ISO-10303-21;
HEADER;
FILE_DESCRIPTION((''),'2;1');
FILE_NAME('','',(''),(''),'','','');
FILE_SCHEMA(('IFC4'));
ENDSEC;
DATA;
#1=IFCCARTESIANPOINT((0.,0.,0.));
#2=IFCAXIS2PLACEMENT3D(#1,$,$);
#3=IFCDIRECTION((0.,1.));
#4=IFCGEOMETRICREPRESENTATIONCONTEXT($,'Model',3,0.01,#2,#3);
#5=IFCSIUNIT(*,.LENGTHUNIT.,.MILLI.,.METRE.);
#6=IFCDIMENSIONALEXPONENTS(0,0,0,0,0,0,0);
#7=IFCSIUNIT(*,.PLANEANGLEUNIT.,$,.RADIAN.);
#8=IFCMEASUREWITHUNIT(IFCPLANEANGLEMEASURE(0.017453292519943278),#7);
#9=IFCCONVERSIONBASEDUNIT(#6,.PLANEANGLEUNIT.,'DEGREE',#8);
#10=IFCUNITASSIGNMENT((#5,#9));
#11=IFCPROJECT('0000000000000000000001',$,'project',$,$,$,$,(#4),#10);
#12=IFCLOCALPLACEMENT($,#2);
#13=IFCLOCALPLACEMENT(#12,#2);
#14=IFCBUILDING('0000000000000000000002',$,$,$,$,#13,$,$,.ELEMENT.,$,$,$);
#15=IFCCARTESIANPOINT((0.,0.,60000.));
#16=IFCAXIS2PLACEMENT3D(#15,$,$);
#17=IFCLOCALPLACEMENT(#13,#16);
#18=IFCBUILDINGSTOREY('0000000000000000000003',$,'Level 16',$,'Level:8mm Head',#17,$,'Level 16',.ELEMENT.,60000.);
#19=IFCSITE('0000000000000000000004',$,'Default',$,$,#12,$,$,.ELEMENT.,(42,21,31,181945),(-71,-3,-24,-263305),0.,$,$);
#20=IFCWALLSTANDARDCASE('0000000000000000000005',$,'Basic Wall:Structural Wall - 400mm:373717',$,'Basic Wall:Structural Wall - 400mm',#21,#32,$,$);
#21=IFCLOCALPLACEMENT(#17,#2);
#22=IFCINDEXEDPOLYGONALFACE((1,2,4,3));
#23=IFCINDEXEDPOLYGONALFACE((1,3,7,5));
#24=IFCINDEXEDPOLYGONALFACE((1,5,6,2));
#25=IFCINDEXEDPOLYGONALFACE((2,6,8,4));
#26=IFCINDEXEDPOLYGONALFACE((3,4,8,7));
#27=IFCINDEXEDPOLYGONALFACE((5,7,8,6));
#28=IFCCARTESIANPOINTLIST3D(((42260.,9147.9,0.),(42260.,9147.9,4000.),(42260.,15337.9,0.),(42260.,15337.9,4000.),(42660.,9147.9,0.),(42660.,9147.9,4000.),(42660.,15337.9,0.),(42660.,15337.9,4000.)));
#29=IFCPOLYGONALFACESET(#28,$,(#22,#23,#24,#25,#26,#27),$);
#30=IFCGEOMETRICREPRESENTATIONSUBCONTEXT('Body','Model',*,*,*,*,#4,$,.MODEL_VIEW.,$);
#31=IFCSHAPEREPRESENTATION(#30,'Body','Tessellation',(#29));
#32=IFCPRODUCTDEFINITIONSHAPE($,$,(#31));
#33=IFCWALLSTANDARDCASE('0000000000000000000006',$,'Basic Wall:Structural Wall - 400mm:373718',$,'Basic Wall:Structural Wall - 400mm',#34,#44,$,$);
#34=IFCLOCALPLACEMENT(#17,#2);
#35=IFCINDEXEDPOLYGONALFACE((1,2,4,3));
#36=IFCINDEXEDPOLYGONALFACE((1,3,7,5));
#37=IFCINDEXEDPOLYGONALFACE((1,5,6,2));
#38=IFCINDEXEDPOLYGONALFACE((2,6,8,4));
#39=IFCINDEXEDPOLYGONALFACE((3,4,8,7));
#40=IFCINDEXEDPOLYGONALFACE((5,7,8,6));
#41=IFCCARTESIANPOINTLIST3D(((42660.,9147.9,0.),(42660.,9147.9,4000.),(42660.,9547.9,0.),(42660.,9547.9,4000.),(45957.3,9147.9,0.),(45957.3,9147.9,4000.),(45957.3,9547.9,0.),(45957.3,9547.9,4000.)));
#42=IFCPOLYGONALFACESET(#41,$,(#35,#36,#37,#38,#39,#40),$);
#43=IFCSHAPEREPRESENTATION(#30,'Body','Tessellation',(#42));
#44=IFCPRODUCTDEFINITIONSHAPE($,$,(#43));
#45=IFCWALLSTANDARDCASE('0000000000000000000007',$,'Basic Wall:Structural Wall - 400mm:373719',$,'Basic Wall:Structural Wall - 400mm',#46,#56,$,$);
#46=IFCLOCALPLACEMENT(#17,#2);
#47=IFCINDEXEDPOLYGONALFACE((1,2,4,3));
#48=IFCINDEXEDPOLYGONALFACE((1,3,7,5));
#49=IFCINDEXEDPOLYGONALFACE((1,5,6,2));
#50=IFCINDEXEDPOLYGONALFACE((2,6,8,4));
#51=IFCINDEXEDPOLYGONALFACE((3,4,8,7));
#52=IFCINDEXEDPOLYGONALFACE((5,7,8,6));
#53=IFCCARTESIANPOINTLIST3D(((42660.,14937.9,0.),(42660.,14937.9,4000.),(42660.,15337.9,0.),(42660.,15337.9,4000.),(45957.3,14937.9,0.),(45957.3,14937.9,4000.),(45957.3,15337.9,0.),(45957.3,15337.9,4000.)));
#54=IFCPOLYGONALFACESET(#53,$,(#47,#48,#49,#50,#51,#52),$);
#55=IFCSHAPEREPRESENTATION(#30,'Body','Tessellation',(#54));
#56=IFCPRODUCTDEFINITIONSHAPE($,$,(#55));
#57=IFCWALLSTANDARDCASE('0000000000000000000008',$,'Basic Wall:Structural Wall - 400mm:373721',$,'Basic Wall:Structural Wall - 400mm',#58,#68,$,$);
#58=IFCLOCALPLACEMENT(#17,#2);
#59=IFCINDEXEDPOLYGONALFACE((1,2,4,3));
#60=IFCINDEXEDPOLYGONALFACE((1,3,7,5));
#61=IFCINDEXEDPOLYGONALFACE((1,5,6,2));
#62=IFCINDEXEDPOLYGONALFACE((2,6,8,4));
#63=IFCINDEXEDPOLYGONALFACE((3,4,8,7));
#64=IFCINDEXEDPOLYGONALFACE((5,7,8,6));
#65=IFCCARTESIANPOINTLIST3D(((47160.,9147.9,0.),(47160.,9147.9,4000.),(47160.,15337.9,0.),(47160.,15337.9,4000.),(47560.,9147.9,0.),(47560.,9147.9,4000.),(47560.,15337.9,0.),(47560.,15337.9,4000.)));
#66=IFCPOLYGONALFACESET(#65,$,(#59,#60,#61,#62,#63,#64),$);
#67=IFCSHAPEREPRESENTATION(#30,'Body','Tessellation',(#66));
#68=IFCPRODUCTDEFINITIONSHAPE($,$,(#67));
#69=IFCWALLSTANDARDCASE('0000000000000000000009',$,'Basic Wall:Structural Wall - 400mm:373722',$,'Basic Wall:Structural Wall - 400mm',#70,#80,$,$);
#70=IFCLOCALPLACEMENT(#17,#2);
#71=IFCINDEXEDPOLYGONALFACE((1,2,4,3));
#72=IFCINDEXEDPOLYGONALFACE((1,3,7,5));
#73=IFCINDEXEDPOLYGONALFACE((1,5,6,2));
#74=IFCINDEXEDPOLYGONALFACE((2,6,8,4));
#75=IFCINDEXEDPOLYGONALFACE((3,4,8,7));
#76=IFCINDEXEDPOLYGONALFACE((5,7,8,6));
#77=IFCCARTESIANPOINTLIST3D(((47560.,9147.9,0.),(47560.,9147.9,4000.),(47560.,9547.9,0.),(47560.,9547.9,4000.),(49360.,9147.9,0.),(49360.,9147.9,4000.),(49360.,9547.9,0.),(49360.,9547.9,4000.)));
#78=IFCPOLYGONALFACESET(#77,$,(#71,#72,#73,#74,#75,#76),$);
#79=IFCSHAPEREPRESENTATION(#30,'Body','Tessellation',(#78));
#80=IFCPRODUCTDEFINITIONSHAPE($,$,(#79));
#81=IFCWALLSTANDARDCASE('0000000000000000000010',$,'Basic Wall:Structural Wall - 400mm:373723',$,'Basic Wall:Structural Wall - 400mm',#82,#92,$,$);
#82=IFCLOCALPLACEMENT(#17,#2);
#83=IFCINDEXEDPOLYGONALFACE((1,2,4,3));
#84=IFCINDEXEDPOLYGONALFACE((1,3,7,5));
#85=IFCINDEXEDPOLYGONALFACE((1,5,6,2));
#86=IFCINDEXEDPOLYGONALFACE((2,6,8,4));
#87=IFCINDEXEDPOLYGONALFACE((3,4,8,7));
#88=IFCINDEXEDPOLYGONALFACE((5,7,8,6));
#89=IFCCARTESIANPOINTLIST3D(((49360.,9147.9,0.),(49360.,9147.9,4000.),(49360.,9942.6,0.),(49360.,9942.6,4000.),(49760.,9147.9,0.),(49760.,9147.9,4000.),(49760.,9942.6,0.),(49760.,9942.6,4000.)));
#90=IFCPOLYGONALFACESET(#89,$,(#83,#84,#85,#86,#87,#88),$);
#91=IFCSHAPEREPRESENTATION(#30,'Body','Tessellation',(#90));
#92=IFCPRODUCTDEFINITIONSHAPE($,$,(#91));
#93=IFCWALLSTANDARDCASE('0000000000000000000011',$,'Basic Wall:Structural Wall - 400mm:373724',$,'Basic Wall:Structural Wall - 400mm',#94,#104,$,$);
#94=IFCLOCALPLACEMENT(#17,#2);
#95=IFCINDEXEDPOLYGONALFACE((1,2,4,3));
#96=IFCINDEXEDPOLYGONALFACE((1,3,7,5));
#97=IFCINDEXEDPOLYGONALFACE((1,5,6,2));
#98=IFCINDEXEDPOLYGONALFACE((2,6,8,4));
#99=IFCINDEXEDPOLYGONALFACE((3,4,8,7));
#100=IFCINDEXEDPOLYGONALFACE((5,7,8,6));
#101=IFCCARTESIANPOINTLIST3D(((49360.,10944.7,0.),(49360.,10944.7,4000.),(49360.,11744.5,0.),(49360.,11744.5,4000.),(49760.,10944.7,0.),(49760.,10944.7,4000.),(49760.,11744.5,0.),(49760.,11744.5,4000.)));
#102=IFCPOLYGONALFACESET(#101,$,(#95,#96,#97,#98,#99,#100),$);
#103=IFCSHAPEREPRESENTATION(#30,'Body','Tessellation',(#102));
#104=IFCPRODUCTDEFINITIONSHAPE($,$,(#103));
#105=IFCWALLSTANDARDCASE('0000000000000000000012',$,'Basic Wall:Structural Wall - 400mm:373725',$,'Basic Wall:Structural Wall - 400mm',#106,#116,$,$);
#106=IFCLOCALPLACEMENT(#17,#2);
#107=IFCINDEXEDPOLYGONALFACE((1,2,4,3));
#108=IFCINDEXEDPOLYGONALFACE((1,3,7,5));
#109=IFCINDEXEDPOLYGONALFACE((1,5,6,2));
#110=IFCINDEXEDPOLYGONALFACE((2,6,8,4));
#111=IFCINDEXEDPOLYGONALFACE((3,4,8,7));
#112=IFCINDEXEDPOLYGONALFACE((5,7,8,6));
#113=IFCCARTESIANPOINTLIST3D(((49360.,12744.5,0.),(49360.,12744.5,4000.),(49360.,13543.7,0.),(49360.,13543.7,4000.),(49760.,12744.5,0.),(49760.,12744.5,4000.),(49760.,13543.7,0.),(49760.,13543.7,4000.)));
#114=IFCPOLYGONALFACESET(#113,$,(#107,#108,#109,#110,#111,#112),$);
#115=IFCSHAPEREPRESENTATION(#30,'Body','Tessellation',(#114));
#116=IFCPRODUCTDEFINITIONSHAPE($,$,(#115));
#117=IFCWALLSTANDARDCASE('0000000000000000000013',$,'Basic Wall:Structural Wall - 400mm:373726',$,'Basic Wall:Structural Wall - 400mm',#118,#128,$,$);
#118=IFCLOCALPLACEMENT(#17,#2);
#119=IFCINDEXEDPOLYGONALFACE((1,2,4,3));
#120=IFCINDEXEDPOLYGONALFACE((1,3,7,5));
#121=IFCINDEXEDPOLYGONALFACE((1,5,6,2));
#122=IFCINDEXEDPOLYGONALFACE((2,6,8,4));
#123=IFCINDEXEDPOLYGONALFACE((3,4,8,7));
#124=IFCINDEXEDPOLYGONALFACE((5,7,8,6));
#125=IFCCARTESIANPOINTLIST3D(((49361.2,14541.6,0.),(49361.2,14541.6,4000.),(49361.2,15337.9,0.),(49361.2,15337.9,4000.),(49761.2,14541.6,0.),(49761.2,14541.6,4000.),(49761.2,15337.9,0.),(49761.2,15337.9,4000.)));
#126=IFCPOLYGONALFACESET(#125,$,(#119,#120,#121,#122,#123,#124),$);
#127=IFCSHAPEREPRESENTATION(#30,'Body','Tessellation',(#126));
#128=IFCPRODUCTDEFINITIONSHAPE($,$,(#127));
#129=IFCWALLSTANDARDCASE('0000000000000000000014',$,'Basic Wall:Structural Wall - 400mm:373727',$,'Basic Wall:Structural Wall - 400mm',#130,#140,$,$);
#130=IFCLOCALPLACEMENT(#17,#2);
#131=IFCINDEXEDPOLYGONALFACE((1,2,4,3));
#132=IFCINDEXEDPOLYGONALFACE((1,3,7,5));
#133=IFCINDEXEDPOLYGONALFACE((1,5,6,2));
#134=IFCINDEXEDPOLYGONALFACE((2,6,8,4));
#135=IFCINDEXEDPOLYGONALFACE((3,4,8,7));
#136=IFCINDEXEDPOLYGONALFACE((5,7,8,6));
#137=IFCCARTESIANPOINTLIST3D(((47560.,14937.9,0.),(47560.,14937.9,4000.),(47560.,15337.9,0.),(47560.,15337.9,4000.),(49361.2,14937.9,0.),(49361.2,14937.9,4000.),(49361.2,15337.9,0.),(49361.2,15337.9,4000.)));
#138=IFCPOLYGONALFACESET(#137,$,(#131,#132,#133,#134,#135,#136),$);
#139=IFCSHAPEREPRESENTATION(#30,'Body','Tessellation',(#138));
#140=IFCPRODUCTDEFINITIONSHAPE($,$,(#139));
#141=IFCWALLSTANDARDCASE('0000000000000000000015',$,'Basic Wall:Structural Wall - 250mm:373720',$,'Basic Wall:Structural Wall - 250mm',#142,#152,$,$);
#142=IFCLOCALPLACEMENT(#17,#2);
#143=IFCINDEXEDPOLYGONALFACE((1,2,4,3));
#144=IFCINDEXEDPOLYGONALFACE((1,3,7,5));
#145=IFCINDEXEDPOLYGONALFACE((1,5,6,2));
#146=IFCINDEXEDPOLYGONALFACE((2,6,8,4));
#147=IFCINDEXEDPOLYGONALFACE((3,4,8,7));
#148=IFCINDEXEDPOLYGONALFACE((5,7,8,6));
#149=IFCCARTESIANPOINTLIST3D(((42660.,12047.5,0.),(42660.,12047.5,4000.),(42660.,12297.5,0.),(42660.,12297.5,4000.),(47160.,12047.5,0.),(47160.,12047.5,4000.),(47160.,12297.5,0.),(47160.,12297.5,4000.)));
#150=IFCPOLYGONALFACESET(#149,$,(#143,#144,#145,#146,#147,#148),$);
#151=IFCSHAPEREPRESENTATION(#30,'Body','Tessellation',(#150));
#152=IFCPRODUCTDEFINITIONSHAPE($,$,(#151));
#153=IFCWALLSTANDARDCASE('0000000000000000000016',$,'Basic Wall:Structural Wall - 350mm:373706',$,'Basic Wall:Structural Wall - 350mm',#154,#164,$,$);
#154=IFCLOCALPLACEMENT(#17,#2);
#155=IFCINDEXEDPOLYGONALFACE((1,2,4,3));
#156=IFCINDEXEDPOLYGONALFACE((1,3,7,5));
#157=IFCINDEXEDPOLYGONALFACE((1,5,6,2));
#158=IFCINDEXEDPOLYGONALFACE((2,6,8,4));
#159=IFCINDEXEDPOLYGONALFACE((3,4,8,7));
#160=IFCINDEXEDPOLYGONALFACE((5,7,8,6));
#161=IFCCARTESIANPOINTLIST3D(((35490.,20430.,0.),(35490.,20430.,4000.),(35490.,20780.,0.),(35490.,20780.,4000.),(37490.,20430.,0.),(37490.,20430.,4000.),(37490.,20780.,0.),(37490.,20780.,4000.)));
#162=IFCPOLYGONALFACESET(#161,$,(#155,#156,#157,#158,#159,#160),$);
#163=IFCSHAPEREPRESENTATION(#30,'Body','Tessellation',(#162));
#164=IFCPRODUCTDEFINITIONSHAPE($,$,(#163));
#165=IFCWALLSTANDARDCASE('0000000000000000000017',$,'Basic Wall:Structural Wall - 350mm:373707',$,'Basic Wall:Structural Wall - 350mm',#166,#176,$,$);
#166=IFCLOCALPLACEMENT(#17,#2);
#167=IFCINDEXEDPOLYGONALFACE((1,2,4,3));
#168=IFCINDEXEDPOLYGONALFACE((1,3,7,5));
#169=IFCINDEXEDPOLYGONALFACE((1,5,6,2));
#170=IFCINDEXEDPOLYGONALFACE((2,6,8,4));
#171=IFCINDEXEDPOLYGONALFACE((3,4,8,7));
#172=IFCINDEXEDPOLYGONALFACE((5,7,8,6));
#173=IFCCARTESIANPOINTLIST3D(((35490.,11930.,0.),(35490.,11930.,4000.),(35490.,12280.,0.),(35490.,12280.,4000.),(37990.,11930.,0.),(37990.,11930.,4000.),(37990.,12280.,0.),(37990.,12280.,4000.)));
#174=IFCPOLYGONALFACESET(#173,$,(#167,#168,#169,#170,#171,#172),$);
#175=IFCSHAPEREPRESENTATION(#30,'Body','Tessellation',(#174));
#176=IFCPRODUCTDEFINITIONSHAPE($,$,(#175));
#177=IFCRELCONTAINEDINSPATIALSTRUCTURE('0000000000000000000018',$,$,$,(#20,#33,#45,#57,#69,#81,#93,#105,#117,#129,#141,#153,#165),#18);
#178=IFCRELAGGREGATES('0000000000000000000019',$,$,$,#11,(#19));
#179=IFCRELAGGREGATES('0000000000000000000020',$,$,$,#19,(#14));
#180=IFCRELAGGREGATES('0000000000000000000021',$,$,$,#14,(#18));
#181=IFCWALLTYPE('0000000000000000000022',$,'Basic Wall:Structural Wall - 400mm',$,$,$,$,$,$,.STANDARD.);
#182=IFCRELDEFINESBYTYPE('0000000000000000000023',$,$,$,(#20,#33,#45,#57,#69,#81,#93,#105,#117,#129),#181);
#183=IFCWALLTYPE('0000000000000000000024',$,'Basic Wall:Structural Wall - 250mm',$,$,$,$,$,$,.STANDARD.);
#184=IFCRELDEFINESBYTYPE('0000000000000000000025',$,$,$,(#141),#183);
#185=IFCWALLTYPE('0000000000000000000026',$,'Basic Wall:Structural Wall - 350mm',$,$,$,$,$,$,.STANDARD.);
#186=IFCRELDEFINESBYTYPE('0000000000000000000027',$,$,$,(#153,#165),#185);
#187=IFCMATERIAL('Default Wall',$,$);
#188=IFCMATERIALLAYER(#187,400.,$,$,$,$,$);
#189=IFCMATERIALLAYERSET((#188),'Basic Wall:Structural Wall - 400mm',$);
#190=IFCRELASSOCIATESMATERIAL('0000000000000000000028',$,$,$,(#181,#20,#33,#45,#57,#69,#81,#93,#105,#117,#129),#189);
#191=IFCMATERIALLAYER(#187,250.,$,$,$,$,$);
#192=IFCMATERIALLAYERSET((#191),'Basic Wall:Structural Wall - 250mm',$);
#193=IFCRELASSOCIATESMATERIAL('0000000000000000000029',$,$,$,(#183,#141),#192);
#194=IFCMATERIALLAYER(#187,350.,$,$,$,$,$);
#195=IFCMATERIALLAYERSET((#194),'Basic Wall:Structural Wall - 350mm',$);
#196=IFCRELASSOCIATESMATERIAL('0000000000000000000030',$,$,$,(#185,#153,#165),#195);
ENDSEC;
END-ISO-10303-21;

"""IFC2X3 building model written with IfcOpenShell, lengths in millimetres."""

from ifc_helpers import new_model, entity, si_unit, converted_unit, direction, frame, frame_2d, origin, place, context, subcontext, project, spatial, rectangle, extrude, material, layer, layer_set, layer_usage, type_object, element, save


model = new_model("IFC2X3")

# Units and contexts
model_context = context("Model", 3, precision=0.01, world=origin(), true_north=direction((0.0, 1.0)))
body_context = subcontext(model_context, "Body", "Model", "MODEL_VIEW")
ifc_project = project(units=[si_unit("LENGTHUNIT", "METRE", prefix="MILLI"), converted_unit("PLANEANGLEUNIT", "DEGREE", entity("IfcPlaneAngleMeasure", 0.017453292519943278), si_unit("PLANEANGLEUNIT", "RADIAN"), dimensions=[0, 0, 0, 0, 0, 0, 0])], contexts=[model_context])

# Site, building, storey
site_placement = place(None, origin())
site = spatial("IfcSite", under=ifc_project, at=site_placement, Name="Default", CompositionType="ELEMENT", RefLatitude=(42, 21, 31, 181945), RefLongitude=(-71, -3, -24, -263305), RefElevation=0.0)
building_placement = place(site_placement, origin())
building = spatial("IfcBuilding", under=site, at=building_placement, CompositionType="ELEMENT")
storey_placement = place(building_placement, frame((0.0, 0.0, 60000.0)))
storey = spatial("IfcBuildingStorey", under=building, at=storey_placement, Name="Level 16", ObjectType="Level:8mm Head", LongName="Level 16", CompositionType="ELEMENT", Elevation=60000.0)

# Walls
ifc_material_1 = material(Name="Default Wall")
ifc_layer_1 = layer(ifc_material_1, 400.0)
ifc_layer_set_1 = layer_set([ifc_layer_1], Name="Basic Wall:Structural Wall - 400mm")
ifc_layer_usage_1 = layer_usage(ifc_layer_set_1, "AXIS2", "POSITIVE", -200.0)
wall_type_1 = type_object("IfcWallType", Name="Basic Wall:Structural Wall - 400mm", PredefinedType="STANDARD", material=ifc_layer_set_1)
wall_1_placement = place(storey_placement, frame((42460.0, 15337.9, 0.0), z_axis=(0.0, 0.0, 1.0), x_axis=(0.0, -1.0, 0.0)))
element("IfcWallStandardCase", 1, at=wall_1_placement, inside=storey, type_object=wall_type_1, material=ifc_layer_usage_1, Name="Basic Wall:Structural Wall - 400mm:373717", ObjectType="Basic Wall:Structural Wall - 400mm", context=body_context, shape_type="SweptSolid", body=[
    extrude(rectangle(XDim=6190.0, YDim=400.0, at=frame_2d((3095.0, 0.0), x_axis=(-1.0, 0.0))), origin(), (0.0, 0.0, 1.0), 4000.0),
])
ifc_layer_usage_2 = layer_usage(ifc_layer_set_1, "AXIS2", "POSITIVE", -200.0)
wall_2_placement = place(storey_placement, frame((42660.0, 9347.9, 0.0)))
element("IfcWallStandardCase", 2, at=wall_2_placement, inside=storey, type_object=wall_type_1, material=ifc_layer_usage_2, Name="Basic Wall:Structural Wall - 400mm:373718", ObjectType="Basic Wall:Structural Wall - 400mm", context=body_context, shape_type="SweptSolid", body=[
    extrude(rectangle(XDim=3297.3, YDim=400.0, at=frame_2d((1648.6, 0.0), x_axis=(-1.0, 0.0))), origin(), (0.0, 0.0, 1.0), 4000.0),
])
ifc_layer_usage_3 = layer_usage(ifc_layer_set_1, "AXIS2", "POSITIVE", -200.0)
wall_3_placement = place(storey_placement, frame((45957.3, 15137.9, 0.0), z_axis=(0.0, 0.0, 1.0), x_axis=(-1.0, 0.0, 0.0)))
element("IfcWallStandardCase", 3, at=wall_3_placement, inside=storey, type_object=wall_type_1, material=ifc_layer_usage_3, Name="Basic Wall:Structural Wall - 400mm:373719", ObjectType="Basic Wall:Structural Wall - 400mm", context=body_context, shape_type="SweptSolid", body=[
    extrude(rectangle(XDim=3297.3, YDim=400.0, at=frame_2d((1648.6, 0.0), x_axis=(-1.0, 0.0))), origin(), (0.0, 0.0, 1.0), 4000.0),
])
ifc_layer_usage_4 = layer_usage(ifc_layer_set_1, "AXIS2", "POSITIVE", -200.0)
wall_4_placement = place(storey_placement, frame((47360.0, 15337.9, 0.0), z_axis=(0.0, 0.0, 1.0), x_axis=(0.0, -1.0, 0.0)))
element("IfcWallStandardCase", 4, at=wall_4_placement, inside=storey, type_object=wall_type_1, material=ifc_layer_usage_4, Name="Basic Wall:Structural Wall - 400mm:373721", ObjectType="Basic Wall:Structural Wall - 400mm", context=body_context, shape_type="SweptSolid", body=[
    extrude(rectangle(XDim=6190.0, YDim=400.0, at=frame_2d((3095.0, 0.0), x_axis=(-1.0, 0.0))), origin(), (0.0, 0.0, 1.0), 4000.0),
])
ifc_layer_usage_5 = layer_usage(ifc_layer_set_1, "AXIS2", "POSITIVE", -200.0)
wall_5_placement = place(storey_placement, frame((47560.0, 9347.9, 0.0)))
element("IfcWallStandardCase", 5, at=wall_5_placement, inside=storey, type_object=wall_type_1, material=ifc_layer_usage_5, Name="Basic Wall:Structural Wall - 400mm:373722", ObjectType="Basic Wall:Structural Wall - 400mm", context=body_context, shape_type="SweptSolid", body=[
    extrude(rectangle(XDim=1800.0, YDim=400.0, at=frame_2d((900.0, 0.0), x_axis=(-1.0, 0.0))), origin(), (0.0, 0.0, 1.0), 4000.0),
])
ifc_layer_usage_6 = layer_usage(ifc_layer_set_1, "AXIS2", "NEGATIVE", 200.0)
wall_6_placement = place(storey_placement, frame((49560.0, 9147.9, 0.0), z_axis=(0.0, 0.0, 1.0), x_axis=(0.0, 1.0, 0.0)))
element("IfcWallStandardCase", 6, at=wall_6_placement, inside=storey, type_object=wall_type_1, material=ifc_layer_usage_6, Name="Basic Wall:Structural Wall - 400mm:373723", ObjectType="Basic Wall:Structural Wall - 400mm", context=body_context, shape_type="SweptSolid", body=[
    extrude(rectangle(XDim=794.7, YDim=400.0, at=frame_2d((397.3, 0.0), x_axis=(-1.0, 0.0))), origin(), (0.0, 0.0, 1.0), 4000.0),
])
ifc_layer_usage_7 = layer_usage(ifc_layer_set_1, "AXIS2", "POSITIVE", -200.0)
wall_7_placement = place(storey_placement, frame((49560.0, 10944.7, 0.0), z_axis=(0.0, 0.0, 1.0), x_axis=(0.0, 1.0, 0.0)))
element("IfcWallStandardCase", 7, at=wall_7_placement, inside=storey, type_object=wall_type_1, material=ifc_layer_usage_7, Name="Basic Wall:Structural Wall - 400mm:373724", ObjectType="Basic Wall:Structural Wall - 400mm", context=body_context, shape_type="SweptSolid", body=[
    extrude(rectangle(XDim=799.8, YDim=400.0, at=frame_2d((399.9, 0.0), x_axis=(-1.0, 0.0))), origin(), (0.0, 0.0, 1.0), 4000.0),
])
ifc_layer_usage_8 = layer_usage(ifc_layer_set_1, "AXIS2", "POSITIVE", -200.0)
wall_8_placement = place(storey_placement, frame((49560.0, 12744.5, 0.0), z_axis=(0.0, 0.0, 1.0), x_axis=(0.0, 1.0, 0.0)))
element("IfcWallStandardCase", 8, at=wall_8_placement, inside=storey, type_object=wall_type_1, material=ifc_layer_usage_8, Name="Basic Wall:Structural Wall - 400mm:373725", ObjectType="Basic Wall:Structural Wall - 400mm", context=body_context, shape_type="SweptSolid", body=[
    extrude(rectangle(XDim=799.2, YDim=400.0, at=frame_2d((399.6, 0.0), x_axis=(-1.0, 0.0))), origin(), (0.0, 0.0, 1.0), 4000.0),
])
ifc_layer_usage_9 = layer_usage(ifc_layer_set_1, "AXIS2", "POSITIVE", -200.0)
wall_9_placement = place(storey_placement, frame((49561.2, 14541.6, 0.0), z_axis=(0.0, 0.0, 1.0), x_axis=(0.0, 1.0, 0.0)))
element("IfcWallStandardCase", 9, at=wall_9_placement, inside=storey, type_object=wall_type_1, material=ifc_layer_usage_9, Name="Basic Wall:Structural Wall - 400mm:373726", ObjectType="Basic Wall:Structural Wall - 400mm", context=body_context, shape_type="SweptSolid", body=[
    extrude(rectangle(XDim=796.3, YDim=400.0, at=frame_2d((398.2, 0.0), x_axis=(-1.0, 0.0))), origin(), (0.0, 0.0, 1.0), 4000.0),
])
ifc_layer_usage_10 = layer_usage(ifc_layer_set_1, "AXIS2", "POSITIVE", -200.0)
wall_10_placement = place(storey_placement, frame((49361.2, 15137.9, 0.0), z_axis=(0.0, 0.0, 1.0), x_axis=(-1.0, 0.0, 0.0)))
element("IfcWallStandardCase", 10, at=wall_10_placement, inside=storey, type_object=wall_type_1, material=ifc_layer_usage_10, Name="Basic Wall:Structural Wall - 400mm:373727", ObjectType="Basic Wall:Structural Wall - 400mm", context=body_context, shape_type="SweptSolid", body=[
    extrude(rectangle(XDim=1801.2, YDim=400.0, at=frame_2d((900.6, 0.0), x_axis=(-1.0, 0.0))), origin(), (0.0, 0.0, 1.0), 4000.0),
])
ifc_layer_2 = layer(ifc_material_1, 250.0)
ifc_layer_set_2 = layer_set([ifc_layer_2], Name="Basic Wall:Structural Wall - 250mm")
ifc_layer_usage_11 = layer_usage(ifc_layer_set_2, "AXIS2", "NEGATIVE", 125.0)
wall_type_2 = type_object("IfcWallType", Name="Basic Wall:Structural Wall - 250mm", PredefinedType="STANDARD", material=ifc_layer_set_2)
wall_11_placement = place(storey_placement, frame((42660.0, 12172.5, 0.0)))
element("IfcWallStandardCase", 11, at=wall_11_placement, inside=storey, type_object=wall_type_2, material=ifc_layer_usage_11, Name="Basic Wall:Structural Wall - 250mm:373720", ObjectType="Basic Wall:Structural Wall - 250mm", context=body_context, shape_type="SweptSolid", body=[
    extrude(rectangle(XDim=4500.0, YDim=250.0, at=frame_2d((2250.0, 0.0), x_axis=(-1.0, 0.0))), origin(), (0.0, 0.0, 1.0), 4000.0),
])
ifc_layer_3 = layer(ifc_material_1, 350.0)
ifc_layer_set_3 = layer_set([ifc_layer_3], Name="Basic Wall:Structural Wall - 350mm")
ifc_layer_usage_12 = layer_usage(ifc_layer_set_3, "AXIS2", "NEGATIVE", 175.0)
wall_type_3 = type_object("IfcWallType", Name="Basic Wall:Structural Wall - 350mm", PredefinedType="STANDARD", material=ifc_layer_set_3)
wall_12_placement = place(storey_placement, frame((35490.0, 20605.0, 0.0)))
element("IfcWallStandardCase", 12, at=wall_12_placement, inside=storey, type_object=wall_type_3, material=ifc_layer_usage_12, Name="Basic Wall:Structural Wall - 350mm:373706", ObjectType="Basic Wall:Structural Wall - 350mm", context=body_context, shape_type="SweptSolid", body=[
    extrude(rectangle(XDim=2000.0, YDim=350.0, at=frame_2d((1000.0, 0.0), x_axis=(-1.0, 0.0))), origin(), (0.0, 0.0, 1.0), 4000.0),
])
ifc_layer_usage_13 = layer_usage(ifc_layer_set_3, "AXIS2", "POSITIVE", -175.0)
wall_13_placement = place(storey_placement, frame((35490.0, 12105.0, 0.0)))
element("IfcWallStandardCase", 13, at=wall_13_placement, inside=storey, type_object=wall_type_3, material=ifc_layer_usage_13, Name="Basic Wall:Structural Wall - 350mm:373707", ObjectType="Basic Wall:Structural Wall - 350mm", context=body_context, shape_type="SweptSolid", body=[
    extrude(rectangle(XDim=2500.0, YDim=350.0, at=frame_2d((1250.0, 0.0), x_axis=(-1.0, 0.0))), origin(), (0.0, 0.0, 1.0), 4000.0),
])

save(model, "model.ifc")
